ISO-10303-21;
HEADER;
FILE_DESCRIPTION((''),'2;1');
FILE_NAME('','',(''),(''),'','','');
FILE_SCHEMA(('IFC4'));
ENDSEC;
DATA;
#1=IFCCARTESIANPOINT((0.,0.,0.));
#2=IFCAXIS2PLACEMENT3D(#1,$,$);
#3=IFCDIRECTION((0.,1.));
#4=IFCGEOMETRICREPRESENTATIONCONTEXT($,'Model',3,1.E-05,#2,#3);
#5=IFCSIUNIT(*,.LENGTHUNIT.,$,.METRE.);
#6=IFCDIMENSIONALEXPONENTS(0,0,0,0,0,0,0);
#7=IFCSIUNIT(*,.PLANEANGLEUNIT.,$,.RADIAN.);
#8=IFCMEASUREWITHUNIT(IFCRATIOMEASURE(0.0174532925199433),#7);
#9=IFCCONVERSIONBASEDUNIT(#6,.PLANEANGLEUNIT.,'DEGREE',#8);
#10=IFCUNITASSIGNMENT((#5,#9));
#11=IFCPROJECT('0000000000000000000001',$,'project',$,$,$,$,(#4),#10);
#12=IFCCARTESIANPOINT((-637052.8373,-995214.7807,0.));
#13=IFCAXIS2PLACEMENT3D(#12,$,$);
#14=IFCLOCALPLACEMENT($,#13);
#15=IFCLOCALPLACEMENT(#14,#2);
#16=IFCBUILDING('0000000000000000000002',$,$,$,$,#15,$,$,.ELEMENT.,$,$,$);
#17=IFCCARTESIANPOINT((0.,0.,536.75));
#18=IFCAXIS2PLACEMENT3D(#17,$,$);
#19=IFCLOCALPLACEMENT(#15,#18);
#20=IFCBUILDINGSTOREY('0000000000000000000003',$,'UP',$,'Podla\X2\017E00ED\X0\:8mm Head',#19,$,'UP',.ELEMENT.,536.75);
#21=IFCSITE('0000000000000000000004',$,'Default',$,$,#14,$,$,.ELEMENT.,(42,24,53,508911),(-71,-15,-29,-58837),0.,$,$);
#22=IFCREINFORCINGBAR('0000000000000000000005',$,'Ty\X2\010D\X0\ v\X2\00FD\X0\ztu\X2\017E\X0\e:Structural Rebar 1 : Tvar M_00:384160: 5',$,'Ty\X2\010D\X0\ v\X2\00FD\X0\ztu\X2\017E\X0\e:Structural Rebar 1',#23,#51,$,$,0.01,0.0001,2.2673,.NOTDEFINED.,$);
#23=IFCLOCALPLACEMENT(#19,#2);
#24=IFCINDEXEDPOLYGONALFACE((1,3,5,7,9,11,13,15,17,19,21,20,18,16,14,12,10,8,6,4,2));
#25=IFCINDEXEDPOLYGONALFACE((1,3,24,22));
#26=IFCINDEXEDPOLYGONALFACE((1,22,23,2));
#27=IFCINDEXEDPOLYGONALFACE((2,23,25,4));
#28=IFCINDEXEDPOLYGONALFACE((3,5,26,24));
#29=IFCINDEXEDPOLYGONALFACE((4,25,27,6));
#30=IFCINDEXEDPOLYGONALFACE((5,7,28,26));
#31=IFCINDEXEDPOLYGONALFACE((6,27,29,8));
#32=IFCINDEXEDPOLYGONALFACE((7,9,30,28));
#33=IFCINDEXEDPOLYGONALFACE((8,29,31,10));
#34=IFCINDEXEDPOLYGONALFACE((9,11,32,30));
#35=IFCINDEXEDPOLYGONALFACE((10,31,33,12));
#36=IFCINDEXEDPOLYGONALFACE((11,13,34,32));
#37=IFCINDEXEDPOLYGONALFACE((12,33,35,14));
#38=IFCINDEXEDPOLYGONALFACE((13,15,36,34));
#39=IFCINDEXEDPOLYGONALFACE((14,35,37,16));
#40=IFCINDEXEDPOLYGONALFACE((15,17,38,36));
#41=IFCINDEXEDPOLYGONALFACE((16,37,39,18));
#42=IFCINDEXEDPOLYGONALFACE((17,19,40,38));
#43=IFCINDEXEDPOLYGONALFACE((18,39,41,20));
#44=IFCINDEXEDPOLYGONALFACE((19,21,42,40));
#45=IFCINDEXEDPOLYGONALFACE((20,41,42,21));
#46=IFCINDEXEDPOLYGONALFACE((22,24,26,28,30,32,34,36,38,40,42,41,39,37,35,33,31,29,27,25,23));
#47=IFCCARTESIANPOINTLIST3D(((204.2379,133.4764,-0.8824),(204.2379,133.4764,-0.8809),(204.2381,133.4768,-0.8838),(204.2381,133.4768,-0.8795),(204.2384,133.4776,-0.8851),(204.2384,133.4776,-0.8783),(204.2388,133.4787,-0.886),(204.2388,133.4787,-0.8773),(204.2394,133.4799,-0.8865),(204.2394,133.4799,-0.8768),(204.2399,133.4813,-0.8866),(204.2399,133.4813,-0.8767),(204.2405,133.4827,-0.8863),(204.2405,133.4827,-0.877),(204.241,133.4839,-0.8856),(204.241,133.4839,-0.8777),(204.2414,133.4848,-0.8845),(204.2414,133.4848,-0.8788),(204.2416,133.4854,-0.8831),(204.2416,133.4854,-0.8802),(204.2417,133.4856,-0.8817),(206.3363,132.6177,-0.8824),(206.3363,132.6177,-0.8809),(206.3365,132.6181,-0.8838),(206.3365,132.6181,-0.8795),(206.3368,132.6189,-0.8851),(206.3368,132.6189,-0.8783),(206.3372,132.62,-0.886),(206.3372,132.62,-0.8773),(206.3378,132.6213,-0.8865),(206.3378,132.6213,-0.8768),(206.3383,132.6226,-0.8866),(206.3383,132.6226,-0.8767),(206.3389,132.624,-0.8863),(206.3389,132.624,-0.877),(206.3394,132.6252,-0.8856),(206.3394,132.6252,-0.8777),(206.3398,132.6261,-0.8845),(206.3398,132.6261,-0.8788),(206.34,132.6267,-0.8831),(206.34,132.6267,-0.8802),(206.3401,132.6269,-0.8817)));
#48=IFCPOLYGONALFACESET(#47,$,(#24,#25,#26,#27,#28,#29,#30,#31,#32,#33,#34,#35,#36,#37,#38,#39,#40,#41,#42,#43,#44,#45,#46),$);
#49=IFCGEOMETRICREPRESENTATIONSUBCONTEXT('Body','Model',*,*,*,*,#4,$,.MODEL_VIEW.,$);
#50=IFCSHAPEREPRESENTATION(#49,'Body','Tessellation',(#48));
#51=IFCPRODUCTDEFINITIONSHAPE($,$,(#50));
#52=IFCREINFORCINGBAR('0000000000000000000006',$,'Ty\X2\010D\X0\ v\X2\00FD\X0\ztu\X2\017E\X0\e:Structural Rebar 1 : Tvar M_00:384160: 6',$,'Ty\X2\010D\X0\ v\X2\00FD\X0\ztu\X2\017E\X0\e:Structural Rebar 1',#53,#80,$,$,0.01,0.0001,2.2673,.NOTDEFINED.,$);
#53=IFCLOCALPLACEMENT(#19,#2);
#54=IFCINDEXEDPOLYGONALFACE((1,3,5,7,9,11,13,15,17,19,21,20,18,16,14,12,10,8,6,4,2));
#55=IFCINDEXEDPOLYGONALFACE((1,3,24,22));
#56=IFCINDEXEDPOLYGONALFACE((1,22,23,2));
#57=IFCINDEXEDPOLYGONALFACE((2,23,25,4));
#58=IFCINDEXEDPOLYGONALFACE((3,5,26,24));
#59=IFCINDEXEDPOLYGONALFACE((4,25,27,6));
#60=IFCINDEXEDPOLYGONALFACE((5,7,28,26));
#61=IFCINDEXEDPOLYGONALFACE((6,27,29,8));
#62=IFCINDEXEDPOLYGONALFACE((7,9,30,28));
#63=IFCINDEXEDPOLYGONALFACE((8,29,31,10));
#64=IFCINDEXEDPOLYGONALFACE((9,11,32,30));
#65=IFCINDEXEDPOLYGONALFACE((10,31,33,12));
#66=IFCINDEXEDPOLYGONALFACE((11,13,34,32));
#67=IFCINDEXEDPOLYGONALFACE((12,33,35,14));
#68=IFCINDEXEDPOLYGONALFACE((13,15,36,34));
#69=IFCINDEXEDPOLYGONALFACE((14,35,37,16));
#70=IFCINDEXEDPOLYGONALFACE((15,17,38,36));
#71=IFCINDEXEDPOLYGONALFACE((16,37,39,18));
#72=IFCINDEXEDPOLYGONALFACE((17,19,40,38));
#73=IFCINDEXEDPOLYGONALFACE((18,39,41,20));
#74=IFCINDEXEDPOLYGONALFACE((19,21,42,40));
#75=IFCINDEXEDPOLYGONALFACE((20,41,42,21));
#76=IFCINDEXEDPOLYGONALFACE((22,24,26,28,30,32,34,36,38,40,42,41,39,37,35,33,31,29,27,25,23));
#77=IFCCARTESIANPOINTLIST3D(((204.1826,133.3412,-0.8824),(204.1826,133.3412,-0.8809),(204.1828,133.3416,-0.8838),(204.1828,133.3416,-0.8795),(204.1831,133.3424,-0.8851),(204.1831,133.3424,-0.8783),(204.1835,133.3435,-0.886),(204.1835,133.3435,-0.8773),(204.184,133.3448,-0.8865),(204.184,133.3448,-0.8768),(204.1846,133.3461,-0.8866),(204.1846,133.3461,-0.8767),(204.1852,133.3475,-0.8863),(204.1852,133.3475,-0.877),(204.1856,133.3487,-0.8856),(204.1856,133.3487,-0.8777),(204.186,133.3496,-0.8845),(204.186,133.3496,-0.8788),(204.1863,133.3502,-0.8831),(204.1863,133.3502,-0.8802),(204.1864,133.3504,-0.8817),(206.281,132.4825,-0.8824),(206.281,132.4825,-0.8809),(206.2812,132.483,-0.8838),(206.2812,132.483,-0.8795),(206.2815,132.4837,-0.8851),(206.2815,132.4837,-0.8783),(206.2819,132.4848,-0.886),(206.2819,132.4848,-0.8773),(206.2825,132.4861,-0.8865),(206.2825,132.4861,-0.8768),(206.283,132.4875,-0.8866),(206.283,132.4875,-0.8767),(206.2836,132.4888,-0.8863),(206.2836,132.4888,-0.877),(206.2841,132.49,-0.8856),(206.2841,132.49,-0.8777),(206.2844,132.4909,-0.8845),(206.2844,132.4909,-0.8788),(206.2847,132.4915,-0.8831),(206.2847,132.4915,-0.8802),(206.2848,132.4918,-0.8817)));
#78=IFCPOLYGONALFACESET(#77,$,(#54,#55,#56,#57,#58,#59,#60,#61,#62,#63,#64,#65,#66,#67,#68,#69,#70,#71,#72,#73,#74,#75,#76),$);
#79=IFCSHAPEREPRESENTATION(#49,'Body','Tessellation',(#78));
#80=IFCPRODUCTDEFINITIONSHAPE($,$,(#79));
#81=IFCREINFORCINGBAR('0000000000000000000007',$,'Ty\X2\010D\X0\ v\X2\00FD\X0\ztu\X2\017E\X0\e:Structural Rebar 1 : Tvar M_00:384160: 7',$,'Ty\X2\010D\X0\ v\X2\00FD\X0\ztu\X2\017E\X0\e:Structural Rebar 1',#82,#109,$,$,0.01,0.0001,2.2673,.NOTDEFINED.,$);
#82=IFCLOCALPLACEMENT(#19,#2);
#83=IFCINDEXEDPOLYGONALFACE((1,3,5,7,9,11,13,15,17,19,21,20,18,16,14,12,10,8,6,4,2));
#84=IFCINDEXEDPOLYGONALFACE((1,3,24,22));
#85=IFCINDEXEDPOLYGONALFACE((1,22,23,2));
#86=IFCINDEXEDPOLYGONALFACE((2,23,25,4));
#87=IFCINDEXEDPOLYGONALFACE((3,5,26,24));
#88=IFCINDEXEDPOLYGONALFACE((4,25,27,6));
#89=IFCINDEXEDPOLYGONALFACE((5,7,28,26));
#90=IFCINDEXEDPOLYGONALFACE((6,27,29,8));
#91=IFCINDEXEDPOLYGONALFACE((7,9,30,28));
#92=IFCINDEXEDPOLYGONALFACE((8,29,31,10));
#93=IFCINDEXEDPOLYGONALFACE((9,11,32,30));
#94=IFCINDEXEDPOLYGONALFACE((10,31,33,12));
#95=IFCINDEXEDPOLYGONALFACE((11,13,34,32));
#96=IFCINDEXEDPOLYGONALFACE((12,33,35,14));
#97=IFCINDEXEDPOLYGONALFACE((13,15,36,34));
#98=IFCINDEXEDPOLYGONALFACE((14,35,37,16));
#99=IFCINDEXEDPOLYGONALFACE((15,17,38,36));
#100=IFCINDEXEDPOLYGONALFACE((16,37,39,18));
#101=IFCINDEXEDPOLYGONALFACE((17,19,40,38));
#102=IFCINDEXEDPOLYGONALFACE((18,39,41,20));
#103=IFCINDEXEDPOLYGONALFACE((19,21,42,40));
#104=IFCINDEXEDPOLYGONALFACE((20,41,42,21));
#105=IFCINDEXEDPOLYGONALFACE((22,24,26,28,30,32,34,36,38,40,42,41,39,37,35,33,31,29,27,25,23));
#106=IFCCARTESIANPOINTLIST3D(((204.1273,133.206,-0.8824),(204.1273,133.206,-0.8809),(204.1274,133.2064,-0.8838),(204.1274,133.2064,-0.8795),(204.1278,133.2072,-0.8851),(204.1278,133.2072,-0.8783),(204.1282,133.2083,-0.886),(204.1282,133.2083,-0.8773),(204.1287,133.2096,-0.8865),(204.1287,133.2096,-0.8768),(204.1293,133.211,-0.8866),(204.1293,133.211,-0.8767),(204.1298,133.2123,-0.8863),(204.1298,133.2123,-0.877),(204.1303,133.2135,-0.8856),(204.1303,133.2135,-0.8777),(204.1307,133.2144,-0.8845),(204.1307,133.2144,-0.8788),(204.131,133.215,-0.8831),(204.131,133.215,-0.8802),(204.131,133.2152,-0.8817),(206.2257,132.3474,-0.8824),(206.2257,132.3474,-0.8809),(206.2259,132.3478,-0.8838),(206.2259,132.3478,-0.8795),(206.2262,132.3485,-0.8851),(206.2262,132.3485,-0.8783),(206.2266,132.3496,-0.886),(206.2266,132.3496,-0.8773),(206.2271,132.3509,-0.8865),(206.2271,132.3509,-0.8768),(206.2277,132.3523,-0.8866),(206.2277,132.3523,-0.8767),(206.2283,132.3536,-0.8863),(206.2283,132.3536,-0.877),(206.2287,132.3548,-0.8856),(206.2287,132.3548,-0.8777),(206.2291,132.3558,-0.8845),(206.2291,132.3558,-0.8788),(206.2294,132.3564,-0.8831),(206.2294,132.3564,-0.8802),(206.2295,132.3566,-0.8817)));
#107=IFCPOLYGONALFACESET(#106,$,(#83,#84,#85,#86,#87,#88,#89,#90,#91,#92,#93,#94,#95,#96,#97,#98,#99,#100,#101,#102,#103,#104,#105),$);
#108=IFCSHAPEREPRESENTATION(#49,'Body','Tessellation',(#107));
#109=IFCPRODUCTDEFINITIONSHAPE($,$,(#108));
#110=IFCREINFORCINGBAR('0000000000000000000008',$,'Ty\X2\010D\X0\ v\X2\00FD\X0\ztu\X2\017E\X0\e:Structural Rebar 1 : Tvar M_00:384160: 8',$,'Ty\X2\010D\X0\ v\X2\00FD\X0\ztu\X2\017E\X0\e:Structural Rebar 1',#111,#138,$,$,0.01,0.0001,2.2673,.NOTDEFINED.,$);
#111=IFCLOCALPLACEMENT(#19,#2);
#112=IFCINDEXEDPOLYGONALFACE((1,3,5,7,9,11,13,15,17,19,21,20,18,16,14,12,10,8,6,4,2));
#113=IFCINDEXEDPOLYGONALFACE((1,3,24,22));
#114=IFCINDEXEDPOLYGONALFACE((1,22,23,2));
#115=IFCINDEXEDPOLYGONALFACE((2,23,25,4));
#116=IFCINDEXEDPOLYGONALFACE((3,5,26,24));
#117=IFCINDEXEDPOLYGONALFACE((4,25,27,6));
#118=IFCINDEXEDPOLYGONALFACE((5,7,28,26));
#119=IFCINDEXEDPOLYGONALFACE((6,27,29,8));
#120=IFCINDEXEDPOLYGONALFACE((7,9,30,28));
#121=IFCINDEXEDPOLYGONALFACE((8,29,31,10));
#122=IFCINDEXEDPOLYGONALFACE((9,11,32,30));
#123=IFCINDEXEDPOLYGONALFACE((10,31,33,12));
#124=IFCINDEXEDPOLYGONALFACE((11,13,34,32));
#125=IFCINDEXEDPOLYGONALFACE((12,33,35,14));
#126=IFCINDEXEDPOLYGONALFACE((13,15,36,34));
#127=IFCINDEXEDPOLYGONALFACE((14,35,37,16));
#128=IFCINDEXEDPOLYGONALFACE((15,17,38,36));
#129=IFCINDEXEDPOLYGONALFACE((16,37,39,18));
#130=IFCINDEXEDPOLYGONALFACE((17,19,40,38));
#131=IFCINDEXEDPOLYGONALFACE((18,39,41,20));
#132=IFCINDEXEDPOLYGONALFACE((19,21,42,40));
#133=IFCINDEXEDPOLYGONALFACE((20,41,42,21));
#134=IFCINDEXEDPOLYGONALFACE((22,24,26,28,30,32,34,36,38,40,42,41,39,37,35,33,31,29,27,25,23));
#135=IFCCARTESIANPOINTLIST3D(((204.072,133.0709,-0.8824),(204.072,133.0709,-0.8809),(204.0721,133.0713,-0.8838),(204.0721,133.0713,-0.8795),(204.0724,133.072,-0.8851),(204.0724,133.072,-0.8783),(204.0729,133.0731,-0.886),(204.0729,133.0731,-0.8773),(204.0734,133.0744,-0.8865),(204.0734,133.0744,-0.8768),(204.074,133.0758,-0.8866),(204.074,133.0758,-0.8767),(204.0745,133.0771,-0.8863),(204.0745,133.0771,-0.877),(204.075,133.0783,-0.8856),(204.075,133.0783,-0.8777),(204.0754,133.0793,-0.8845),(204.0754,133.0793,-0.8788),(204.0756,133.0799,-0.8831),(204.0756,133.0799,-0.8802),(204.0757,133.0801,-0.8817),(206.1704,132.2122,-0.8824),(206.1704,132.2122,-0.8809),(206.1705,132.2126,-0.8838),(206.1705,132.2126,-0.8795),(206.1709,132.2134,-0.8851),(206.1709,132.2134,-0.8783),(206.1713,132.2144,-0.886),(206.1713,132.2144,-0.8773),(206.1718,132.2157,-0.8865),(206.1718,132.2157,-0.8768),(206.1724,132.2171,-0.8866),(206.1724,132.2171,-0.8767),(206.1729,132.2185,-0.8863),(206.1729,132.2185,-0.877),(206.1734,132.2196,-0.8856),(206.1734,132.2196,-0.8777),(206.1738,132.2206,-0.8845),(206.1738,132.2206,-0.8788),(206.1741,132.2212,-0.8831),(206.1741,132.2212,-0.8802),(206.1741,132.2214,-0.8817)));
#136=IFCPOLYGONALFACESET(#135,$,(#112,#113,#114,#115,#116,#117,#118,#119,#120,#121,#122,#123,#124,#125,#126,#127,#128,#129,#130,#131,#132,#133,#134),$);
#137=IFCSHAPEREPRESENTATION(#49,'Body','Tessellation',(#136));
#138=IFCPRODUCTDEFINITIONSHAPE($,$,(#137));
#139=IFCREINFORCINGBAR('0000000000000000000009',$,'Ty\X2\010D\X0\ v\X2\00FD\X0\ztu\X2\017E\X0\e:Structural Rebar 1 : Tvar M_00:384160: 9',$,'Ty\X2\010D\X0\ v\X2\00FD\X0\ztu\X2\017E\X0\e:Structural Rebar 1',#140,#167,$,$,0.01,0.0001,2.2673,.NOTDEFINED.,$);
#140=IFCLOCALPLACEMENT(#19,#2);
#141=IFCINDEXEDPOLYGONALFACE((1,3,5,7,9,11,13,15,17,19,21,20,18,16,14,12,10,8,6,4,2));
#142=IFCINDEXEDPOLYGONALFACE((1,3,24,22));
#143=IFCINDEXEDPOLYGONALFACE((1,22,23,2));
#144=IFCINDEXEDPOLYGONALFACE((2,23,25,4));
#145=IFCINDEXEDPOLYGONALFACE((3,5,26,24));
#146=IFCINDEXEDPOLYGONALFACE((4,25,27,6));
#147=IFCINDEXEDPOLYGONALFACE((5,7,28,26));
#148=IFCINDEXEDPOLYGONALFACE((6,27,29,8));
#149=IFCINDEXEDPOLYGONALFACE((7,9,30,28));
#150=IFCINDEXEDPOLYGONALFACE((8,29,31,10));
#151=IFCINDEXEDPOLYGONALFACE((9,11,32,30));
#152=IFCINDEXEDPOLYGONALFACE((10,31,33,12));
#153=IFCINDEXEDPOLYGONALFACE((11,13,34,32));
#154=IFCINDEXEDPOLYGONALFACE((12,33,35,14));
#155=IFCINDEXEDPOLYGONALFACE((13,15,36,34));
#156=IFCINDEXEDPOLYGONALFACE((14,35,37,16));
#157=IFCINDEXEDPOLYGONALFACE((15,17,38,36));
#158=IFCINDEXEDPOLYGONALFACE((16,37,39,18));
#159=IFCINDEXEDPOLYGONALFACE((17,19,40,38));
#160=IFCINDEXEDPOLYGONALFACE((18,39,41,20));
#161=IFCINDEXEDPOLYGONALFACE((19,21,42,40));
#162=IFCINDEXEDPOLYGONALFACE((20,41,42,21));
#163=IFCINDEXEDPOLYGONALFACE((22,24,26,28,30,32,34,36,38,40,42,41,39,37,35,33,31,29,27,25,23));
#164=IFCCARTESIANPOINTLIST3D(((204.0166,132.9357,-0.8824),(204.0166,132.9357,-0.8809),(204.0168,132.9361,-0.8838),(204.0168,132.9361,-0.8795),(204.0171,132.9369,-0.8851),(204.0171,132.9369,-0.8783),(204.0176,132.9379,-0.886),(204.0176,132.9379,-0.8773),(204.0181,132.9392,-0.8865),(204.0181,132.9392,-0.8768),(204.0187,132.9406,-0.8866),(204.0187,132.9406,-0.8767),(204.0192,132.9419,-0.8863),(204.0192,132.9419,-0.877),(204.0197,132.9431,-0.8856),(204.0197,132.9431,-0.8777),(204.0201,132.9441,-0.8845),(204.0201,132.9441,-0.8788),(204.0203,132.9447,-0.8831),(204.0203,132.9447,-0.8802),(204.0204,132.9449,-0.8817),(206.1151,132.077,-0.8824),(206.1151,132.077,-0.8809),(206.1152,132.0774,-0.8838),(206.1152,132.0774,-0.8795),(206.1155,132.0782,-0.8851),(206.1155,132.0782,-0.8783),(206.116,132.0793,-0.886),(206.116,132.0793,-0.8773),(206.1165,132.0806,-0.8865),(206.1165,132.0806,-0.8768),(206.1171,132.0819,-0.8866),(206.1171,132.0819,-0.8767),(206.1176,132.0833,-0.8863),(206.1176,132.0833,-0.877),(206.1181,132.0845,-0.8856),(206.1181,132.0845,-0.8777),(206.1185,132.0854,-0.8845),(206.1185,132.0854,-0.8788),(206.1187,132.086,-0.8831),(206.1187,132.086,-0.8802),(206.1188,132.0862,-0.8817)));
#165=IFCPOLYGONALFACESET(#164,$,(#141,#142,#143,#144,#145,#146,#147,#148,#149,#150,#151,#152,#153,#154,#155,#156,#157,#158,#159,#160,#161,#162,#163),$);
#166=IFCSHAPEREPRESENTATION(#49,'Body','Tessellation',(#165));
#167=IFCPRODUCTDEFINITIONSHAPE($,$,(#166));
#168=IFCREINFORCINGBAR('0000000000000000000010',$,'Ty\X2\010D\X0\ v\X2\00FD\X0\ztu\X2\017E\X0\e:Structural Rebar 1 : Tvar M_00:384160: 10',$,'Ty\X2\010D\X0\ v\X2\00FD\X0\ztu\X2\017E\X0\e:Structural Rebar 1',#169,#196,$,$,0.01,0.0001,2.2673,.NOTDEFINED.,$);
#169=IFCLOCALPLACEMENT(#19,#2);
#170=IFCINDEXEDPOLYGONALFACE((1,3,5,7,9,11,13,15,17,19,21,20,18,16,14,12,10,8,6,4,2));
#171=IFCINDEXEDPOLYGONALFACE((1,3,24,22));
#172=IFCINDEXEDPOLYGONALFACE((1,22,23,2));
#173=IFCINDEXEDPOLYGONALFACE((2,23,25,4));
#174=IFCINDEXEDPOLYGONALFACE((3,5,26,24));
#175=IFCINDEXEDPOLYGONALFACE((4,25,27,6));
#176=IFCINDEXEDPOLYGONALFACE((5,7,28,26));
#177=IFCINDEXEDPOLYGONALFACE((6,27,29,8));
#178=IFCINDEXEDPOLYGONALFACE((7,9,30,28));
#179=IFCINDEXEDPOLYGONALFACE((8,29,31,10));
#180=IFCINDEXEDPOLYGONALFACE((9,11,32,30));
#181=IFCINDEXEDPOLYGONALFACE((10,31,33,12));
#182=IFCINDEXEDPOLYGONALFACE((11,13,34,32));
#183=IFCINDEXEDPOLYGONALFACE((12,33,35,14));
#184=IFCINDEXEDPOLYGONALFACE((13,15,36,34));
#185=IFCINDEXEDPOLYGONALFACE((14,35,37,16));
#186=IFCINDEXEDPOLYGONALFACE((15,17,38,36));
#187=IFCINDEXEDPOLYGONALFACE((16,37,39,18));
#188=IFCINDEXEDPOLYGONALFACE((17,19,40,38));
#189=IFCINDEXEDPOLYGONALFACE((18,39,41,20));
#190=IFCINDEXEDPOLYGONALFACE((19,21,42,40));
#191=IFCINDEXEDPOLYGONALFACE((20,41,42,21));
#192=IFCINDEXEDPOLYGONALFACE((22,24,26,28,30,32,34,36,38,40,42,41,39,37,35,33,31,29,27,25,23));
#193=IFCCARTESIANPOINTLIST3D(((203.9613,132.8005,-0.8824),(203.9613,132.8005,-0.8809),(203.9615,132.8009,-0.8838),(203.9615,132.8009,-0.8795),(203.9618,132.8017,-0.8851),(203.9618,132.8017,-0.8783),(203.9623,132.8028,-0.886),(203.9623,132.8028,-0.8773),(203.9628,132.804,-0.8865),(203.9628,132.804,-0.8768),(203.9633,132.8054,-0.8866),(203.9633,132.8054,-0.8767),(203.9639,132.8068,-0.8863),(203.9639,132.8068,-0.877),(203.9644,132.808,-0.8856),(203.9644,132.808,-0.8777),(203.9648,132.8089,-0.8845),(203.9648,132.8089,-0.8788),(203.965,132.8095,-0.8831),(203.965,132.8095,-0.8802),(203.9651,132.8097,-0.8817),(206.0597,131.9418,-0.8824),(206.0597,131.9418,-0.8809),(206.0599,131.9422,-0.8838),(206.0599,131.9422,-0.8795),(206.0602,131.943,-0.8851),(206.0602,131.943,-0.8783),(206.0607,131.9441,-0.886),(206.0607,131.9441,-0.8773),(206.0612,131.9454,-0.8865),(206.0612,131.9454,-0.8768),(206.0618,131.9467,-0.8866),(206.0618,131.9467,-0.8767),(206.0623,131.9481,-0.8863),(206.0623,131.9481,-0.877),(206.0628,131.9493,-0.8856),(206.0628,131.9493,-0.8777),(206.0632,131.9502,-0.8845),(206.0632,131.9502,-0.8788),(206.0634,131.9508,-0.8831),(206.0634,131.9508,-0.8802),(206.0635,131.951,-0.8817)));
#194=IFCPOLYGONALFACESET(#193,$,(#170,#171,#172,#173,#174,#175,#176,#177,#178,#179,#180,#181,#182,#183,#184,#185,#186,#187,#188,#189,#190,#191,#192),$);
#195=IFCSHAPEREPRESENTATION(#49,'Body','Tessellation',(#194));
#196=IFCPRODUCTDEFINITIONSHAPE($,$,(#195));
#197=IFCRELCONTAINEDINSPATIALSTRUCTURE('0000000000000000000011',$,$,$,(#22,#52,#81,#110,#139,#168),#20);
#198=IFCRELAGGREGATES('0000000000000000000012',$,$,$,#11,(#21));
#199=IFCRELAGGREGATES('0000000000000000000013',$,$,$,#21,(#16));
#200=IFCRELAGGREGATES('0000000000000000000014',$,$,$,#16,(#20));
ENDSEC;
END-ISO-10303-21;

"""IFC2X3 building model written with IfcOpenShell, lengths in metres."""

from ifc_helpers import new_model, entity, si_unit, converted_unit, direction, frame, origin, place, context, subcontext, project, spatial, element, save


model = new_model("IFC2X3")

# Units and contexts
model_context = context("Model", 3, precision=1e-05, world=origin(), true_north=direction((0.0, 1.0)))
body_context = subcontext(model_context, "Body", "Model", "MODEL_VIEW")
ifc_project = project(units=[si_unit("LENGTHUNIT", "METRE"), converted_unit("PLANEANGLEUNIT", "DEGREE", entity("IfcRatioMeasure", 0.0174532925199433), si_unit("PLANEANGLEUNIT", "RADIAN"), dimensions=[0, 0, 0, 0, 0, 0, 0])], contexts=[model_context])

# Site, building, storey
site_placement = place(None, frame((-637052.8373, -995214.7807, 0.0)))
site = spatial("IfcSite", under=ifc_project, at=site_placement, Name="Default", CompositionType="ELEMENT", RefLatitude=(42, 24, 53, 508911), RefLongitude=(-71, -15, -29, -58837), RefElevation=0.0)
building_placement = place(site_placement, origin())
building = spatial("IfcBuilding", under=site, at=building_placement, CompositionType="ELEMENT")
storey_placement = place(building_placement, frame((0.0, 0.0, 536.75)))
storey = spatial("IfcBuildingStorey", under=building, at=storey_placement, Name="UP", ObjectType="Podlaží:8mm Head", LongName="UP", CompositionType="ELEMENT", Elevation=536.75)

# Reinforcing bars
reinforcing_bar_1_placement = place(storey_placement, origin())
element("IfcReinforcingBar", 1, at=reinforcing_bar_1_placement, inside=storey, Name="Tyč výztuže:Structural Rebar 1 : Tvar M_00:384160: 5", ObjectType="Tyč výztuže:Structural Rebar 1", BarLength=2.2673, BarRole="NOTDEFINED", CrossSectionArea=0.0001, NominalDiameter=0.01, context=body_context, shape_type="AdvancedSweptSolid", body=[
    entity("IfcSweptDiskSolid", entity("IfcCompositeCurve", [entity("IfcCompositeCurveSegment", "CONTINUOUS", True, entity("IfcPolyline", [entity("IfcCartesianPoint", [-206.3382, -132.6223, 0.8817]), entity("IfcCartesianPoint", [-204.2398, -133.481, 0.8817])]))], False), 0.005, None, 0.0, 1.0),
])
reinforcing_bar_2_placement = place(storey_placement, origin())
element("IfcReinforcingBar", 2, at=reinforcing_bar_2_placement, inside=storey, Name="Tyč výztuže:Structural Rebar 1 : Tvar M_00:384160: 6", ObjectType="Tyč výztuže:Structural Rebar 1", BarLength=2.2673, BarRole="NOTDEFINED", CrossSectionArea=0.0001, NominalDiameter=0.01, context=body_context, shape_type="AdvancedSweptSolid", body=[
    entity("IfcSweptDiskSolid", entity("IfcCompositeCurve", [entity("IfcCompositeCurveSegment", "CONTINUOUS", True, entity("IfcPolyline", [entity("IfcCartesianPoint", [-206.2829, -132.4871, 0.8817]), entity("IfcCartesianPoint", [-204.1845, -133.3458, 0.8817])]))], False), 0.005, None, 0.0, 1.0),
])
reinforcing_bar_3_placement = place(storey_placement, origin())
element("IfcReinforcingBar", 3, at=reinforcing_bar_3_placement, inside=storey, Name="Tyč výztuže:Structural Rebar 1 : Tvar M_00:384160: 7", ObjectType="Tyč výztuže:Structural Rebar 1", BarLength=2.2673, BarRole="NOTDEFINED", CrossSectionArea=0.0001, NominalDiameter=0.01, context=body_context, shape_type="AdvancedSweptSolid", body=[
    entity("IfcSweptDiskSolid", entity("IfcCompositeCurve", [entity("IfcCompositeCurveSegment", "CONTINUOUS", True, entity("IfcPolyline", [entity("IfcCartesianPoint", [-206.2276, -132.3519, 0.8817]), entity("IfcCartesianPoint", [-204.1292, -133.2106, 0.8817])]))], False), 0.005, None, 0.0, 1.0),
])
reinforcing_bar_4_placement = place(storey_placement, origin())
element("IfcReinforcingBar", 4, at=reinforcing_bar_4_placement, inside=storey, Name="Tyč výztuže:Structural Rebar 1 : Tvar M_00:384160: 8", ObjectType="Tyč výztuže:Structural Rebar 1", BarLength=2.2673, BarRole="NOTDEFINED", CrossSectionArea=0.0001, NominalDiameter=0.01, context=body_context, shape_type="AdvancedSweptSolid", body=[
    entity("IfcSweptDiskSolid", entity("IfcCompositeCurve", [entity("IfcCompositeCurveSegment", "CONTINUOUS", True, entity("IfcPolyline", [entity("IfcCartesianPoint", [-206.1722, -132.2168, 0.8817]), entity("IfcCartesianPoint", [-204.0738, -133.0754, 0.8817])]))], False), 0.005, None, 0.0, 1.0),
])
reinforcing_bar_5_placement = place(storey_placement, origin())
element("IfcReinforcingBar", 5, at=reinforcing_bar_5_placement, inside=storey, Name="Tyč výztuže:Structural Rebar 1 : Tvar M_00:384160: 9", ObjectType="Tyč výztuže:Structural Rebar 1", BarLength=2.2673, BarRole="NOTDEFINED", CrossSectionArea=0.0001, NominalDiameter=0.01, context=body_context, shape_type="AdvancedSweptSolid", body=[
    entity("IfcSweptDiskSolid", entity("IfcCompositeCurve", [entity("IfcCompositeCurveSegment", "CONTINUOUS", True, entity("IfcPolyline", [entity("IfcCartesianPoint", [-206.1169, -132.0816, 0.8817]), entity("IfcCartesianPoint", [-204.0185, -132.9403, 0.8817])]))], False), 0.005, None, 0.0, 1.0),
])
reinforcing_bar_6_placement = place(storey_placement, origin())
element("IfcReinforcingBar", 6, at=reinforcing_bar_6_placement, inside=storey, Name="Tyč výztuže:Structural Rebar 1 : Tvar M_00:384160: 10", ObjectType="Tyč výztuže:Structural Rebar 1", BarLength=2.2673, BarRole="NOTDEFINED", CrossSectionArea=0.0001, NominalDiameter=0.01, context=body_context, shape_type="AdvancedSweptSolid", body=[
    entity("IfcSweptDiskSolid", entity("IfcCompositeCurve", [entity("IfcCompositeCurveSegment", "CONTINUOUS", True, entity("IfcPolyline", [entity("IfcCartesianPoint", [-206.0616, -131.9464, 0.8817]), entity("IfcCartesianPoint", [-203.9632, -132.8051, 0.8817])]))], False), 0.005, None, 0.0, 1.0),
])

save(model, "model.ifc")
